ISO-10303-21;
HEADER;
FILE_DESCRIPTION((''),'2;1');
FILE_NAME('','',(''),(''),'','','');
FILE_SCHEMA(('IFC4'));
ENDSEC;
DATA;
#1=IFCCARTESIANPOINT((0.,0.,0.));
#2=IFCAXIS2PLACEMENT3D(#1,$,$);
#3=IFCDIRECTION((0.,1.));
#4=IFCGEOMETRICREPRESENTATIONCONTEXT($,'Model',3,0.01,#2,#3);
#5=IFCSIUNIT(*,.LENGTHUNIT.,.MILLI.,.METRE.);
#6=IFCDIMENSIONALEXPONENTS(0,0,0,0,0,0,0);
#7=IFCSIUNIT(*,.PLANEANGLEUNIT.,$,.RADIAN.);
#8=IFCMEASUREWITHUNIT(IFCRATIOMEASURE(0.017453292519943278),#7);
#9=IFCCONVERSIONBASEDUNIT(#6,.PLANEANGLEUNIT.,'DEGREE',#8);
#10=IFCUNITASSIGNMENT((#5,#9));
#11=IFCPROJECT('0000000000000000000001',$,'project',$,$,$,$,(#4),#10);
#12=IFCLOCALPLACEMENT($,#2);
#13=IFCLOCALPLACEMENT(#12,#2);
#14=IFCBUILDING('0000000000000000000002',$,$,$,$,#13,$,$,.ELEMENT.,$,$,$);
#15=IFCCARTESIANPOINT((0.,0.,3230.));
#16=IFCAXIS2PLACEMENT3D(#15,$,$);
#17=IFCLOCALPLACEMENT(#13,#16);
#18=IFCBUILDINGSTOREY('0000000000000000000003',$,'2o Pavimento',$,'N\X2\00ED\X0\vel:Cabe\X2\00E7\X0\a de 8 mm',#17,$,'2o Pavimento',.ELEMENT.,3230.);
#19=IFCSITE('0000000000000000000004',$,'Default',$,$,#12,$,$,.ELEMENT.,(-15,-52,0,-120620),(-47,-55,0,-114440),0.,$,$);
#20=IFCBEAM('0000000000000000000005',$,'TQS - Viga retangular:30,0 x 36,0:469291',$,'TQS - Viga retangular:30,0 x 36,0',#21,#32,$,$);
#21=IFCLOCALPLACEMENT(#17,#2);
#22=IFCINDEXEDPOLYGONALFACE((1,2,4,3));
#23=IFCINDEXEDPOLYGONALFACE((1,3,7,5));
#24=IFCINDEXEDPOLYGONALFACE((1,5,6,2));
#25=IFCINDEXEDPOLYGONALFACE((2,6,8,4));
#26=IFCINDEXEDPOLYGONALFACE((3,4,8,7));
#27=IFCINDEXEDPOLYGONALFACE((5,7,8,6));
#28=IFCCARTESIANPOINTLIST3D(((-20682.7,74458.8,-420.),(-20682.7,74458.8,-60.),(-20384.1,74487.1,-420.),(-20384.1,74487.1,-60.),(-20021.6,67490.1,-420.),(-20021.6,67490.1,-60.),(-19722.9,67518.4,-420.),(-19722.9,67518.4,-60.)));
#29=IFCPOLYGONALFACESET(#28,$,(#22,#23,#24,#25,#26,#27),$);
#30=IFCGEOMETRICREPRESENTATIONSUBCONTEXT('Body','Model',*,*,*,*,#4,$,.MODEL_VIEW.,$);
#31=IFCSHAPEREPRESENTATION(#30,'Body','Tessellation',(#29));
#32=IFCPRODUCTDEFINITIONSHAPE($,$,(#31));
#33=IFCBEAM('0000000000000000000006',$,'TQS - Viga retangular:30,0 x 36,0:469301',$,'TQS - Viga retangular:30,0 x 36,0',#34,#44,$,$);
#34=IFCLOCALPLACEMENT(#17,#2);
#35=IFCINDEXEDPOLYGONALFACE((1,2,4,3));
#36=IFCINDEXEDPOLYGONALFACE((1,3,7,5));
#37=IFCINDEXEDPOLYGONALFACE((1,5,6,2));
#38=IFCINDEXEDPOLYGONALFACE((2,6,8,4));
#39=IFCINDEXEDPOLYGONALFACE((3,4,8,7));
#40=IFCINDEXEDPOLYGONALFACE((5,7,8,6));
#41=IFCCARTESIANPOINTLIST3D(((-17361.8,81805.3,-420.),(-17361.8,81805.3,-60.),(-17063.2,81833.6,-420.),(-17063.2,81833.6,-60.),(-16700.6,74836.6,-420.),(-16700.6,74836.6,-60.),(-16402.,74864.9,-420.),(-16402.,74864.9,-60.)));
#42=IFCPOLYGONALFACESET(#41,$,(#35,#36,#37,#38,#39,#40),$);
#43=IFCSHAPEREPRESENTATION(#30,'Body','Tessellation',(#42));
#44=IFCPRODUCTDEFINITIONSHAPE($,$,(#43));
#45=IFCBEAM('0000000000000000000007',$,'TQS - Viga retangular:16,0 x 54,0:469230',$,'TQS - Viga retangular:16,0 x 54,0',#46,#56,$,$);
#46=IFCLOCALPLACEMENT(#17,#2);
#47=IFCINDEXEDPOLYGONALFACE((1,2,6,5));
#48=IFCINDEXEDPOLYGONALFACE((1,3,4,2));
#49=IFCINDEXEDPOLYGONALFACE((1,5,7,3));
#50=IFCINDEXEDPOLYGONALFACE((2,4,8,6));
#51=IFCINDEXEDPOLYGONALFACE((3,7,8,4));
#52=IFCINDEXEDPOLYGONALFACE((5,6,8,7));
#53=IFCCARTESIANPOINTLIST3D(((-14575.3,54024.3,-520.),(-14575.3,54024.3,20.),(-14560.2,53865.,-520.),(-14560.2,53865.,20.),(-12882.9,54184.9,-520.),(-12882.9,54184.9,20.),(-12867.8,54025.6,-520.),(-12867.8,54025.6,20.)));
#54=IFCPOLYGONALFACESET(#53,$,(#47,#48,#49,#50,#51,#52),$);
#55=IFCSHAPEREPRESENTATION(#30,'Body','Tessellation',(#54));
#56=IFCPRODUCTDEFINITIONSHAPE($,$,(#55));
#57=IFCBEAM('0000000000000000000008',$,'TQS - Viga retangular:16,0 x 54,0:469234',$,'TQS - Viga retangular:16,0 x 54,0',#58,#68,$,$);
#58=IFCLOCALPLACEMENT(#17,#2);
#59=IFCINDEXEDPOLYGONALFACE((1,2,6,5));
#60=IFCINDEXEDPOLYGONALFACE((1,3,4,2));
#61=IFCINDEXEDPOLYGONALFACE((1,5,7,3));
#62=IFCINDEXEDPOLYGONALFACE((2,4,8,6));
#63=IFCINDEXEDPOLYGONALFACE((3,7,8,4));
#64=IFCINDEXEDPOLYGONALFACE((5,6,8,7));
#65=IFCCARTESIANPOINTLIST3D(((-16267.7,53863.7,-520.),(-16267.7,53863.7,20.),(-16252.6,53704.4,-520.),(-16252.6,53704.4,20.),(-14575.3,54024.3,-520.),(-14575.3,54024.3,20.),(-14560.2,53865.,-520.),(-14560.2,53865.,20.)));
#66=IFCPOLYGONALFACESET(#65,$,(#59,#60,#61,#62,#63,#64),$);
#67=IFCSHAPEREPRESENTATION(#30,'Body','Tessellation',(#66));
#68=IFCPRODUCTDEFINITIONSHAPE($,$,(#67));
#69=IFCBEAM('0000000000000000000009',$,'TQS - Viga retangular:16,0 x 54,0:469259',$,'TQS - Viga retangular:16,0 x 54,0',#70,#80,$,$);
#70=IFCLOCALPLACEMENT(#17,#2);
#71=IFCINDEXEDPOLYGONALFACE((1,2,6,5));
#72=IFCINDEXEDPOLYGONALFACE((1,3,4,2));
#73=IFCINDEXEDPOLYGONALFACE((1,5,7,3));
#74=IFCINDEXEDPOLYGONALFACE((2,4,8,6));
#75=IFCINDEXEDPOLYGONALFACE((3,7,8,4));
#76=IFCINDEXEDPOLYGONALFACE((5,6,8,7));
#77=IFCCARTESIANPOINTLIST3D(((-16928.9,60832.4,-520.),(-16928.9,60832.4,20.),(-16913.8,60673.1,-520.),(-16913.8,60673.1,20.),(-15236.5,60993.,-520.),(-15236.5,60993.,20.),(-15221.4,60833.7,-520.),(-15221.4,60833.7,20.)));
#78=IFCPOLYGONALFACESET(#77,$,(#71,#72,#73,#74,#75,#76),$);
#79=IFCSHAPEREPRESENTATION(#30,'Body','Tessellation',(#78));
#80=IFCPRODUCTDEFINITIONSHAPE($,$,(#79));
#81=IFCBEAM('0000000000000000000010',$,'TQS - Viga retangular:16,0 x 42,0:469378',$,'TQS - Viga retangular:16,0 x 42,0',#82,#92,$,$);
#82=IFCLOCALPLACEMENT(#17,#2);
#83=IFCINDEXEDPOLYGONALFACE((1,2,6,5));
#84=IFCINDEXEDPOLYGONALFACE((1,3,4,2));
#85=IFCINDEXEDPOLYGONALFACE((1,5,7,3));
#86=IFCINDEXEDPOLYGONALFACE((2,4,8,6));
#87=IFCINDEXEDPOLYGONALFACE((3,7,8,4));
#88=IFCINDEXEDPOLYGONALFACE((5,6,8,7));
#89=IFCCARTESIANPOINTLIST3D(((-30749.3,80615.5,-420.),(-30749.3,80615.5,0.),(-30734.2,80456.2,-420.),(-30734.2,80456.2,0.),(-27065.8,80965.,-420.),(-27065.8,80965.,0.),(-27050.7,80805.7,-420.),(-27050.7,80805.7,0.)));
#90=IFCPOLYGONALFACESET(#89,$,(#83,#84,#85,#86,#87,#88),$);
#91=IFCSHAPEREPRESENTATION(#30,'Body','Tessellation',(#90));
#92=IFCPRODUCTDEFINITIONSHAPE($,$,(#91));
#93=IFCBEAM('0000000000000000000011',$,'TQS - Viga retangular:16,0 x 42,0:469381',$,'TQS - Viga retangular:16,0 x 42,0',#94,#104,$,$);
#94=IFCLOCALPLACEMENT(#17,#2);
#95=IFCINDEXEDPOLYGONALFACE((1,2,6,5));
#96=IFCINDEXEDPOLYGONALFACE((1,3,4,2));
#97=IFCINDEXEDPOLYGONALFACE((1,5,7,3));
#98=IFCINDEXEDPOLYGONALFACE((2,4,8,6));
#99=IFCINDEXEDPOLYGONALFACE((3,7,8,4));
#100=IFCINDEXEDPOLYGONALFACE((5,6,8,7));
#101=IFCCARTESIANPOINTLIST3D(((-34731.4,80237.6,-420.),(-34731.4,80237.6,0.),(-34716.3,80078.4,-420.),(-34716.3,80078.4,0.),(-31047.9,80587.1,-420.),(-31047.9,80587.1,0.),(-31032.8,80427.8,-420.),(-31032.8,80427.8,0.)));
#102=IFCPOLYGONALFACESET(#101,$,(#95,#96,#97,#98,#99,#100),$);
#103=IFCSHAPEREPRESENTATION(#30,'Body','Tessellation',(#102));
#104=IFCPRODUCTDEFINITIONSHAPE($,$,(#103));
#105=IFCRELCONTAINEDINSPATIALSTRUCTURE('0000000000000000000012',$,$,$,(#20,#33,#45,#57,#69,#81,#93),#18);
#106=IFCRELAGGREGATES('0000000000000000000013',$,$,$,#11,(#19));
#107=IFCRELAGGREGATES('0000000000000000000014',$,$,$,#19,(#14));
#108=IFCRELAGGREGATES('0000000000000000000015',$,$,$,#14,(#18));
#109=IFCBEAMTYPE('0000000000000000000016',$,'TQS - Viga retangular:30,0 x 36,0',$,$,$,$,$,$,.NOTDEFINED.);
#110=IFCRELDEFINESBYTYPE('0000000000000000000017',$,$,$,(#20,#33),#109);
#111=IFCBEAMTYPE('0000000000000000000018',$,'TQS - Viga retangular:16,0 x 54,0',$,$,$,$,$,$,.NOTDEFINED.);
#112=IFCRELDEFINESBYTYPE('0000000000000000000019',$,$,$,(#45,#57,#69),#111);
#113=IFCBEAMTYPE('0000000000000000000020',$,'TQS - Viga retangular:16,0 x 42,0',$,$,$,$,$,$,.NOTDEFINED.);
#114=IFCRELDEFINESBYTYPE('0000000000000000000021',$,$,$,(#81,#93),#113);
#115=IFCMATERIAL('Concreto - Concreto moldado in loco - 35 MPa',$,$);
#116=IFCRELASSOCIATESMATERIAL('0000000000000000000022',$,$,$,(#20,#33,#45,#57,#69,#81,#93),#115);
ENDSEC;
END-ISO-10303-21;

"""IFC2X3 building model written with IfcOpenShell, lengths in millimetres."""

from ifc_helpers import new_model, entity, si_unit, converted_unit, direction, frame, frame_2d, origin, origin_2d_with_axis, place, context, subcontext, project, spatial, rectangle, extrude, material, type_object, element, save


model = new_model("IFC2X3")

# Units and contexts
model_context = context("Model", 3, precision=0.01, world=origin(), true_north=direction((0.0, 1.0)))
body_context = subcontext(model_context, "Body", "Model", "MODEL_VIEW")
ifc_project = project(units=[si_unit("LENGTHUNIT", "METRE", prefix="MILLI"), converted_unit("PLANEANGLEUNIT", "DEGREE", entity("IfcRatioMeasure", 0.017453292519943278), si_unit("PLANEANGLEUNIT", "RADIAN"), dimensions=[0, 0, 0, 0, 0, 0, 0])], contexts=[model_context])

# Site, building, storey
site_placement = place(None, origin())
site = spatial("IfcSite", under=ifc_project, at=site_placement, Name="Default", CompositionType="ELEMENT", RefLatitude=(-15, -52, 0, -120620), RefLongitude=(-47, -55, 0, -114440), RefElevation=0.0)
building_placement = place(site_placement, origin())
building = spatial("IfcBuilding", under=site, at=building_placement, CompositionType="ELEMENT")
storey_placement = place(building_placement, frame((0.0, 0.0, 3230.0)))
storey = spatial("IfcBuildingStorey", under=building, at=storey_placement, Name="2o Pavimento", ObjectType="Nível:Cabeça de 8 mm", LongName="2o Pavimento", CompositionType="ELEMENT", Elevation=3230.0)

# Beams
ifc_material = material(Name="Concreto - Concreto moldado in loco - 35 MPa")
beam_type_1 = type_object("IfcBeamType", Name="TQS - Viga retangular:30,0 x 36,0", PredefinedType="NOTDEFINED")
beam_1_placement = place(storey_placement, frame((-19872.2, 67504.2, -60.0), z_axis=(0.0, 0.0, 1.0), x_axis=(-0.094456, 0.995529, 0.0)))
element("IfcBeam", 1, at=beam_1_placement, inside=storey, type_object=beam_type_1, material=ifc_material, Name="TQS - Viga retangular:30,0 x 36,0:469291", ObjectType="TQS - Viga retangular:30,0 x 36,0", context=body_context, shape_type="SweptSolid", body=[
    extrude(rectangle(XDim=360.0, YDim=300.0, at=frame_2d((0.0, 0.0), x_axis=(1.0, 0.0))), frame((0.0, 0.0, -180.0), z_axis=(1.0, 0.0, 0.0), x_axis=(0.0, 0.0, -1.0)), (0.0, 0.0, 1.0), 7000.0),
])
beam_2_placement = place(storey_placement, frame((-16551.3, 74850.8, -60.0), z_axis=(0.0, 0.0, 1.0), x_axis=(-0.094456, 0.995529, 0.0)))
element("IfcBeam", 2, at=beam_2_placement, inside=storey, type_object=beam_type_1, material=ifc_material, Name="TQS - Viga retangular:30,0 x 36,0:469301", ObjectType="TQS - Viga retangular:30,0 x 36,0", context=body_context, shape_type="SweptSolid", body=[
    extrude(rectangle(XDim=360.0, YDim=300.0, at=frame_2d((0.0, 0.0), x_axis=(1.0, 0.0))), frame((0.0, 0.0, -180.0), z_axis=(1.0, 0.0, 0.0), x_axis=(0.0, 0.0, -1.0)), (0.0, 0.0, 1.0), 7000.0),
])
beam_type_2 = type_object("IfcBeamType", Name="TQS - Viga retangular:16,0 x 54,0", PredefinedType="NOTDEFINED")
beam_3_placement = place(storey_placement, frame((-12875.3, 54105.2, 20.0), z_axis=(0.0, 0.0, 1.0), x_axis=(-0.995529, -0.094456, 0.0)))
element("IfcBeam", 3, at=beam_3_placement, inside=storey, type_object=beam_type_2, material=ifc_material, Name="TQS - Viga retangular:16,0 x 54,0:469230", ObjectType="TQS - Viga retangular:16,0 x 54,0", context=body_context, shape_type="SweptSolid", body=[
    extrude(rectangle(XDim=540.0, YDim=160.0, at=frame_2d((0.0, 0.0), x_axis=(1.0, 0.0))), frame((0.0, 0.0, -270.0), z_axis=(1.0, 0.0, 0.0), x_axis=(0.0, 0.0, -1.0)), (0.0, 0.0, 1.0), 1700.0),
])
beam_4_placement = place(storey_placement, frame((-14567.7, 53944.7, 20.0), z_axis=(0.0, 0.0, 1.0), x_axis=(-0.995529, -0.094456, 0.0)))
element("IfcBeam", 4, at=beam_4_placement, inside=storey, type_object=beam_type_2, material=ifc_material, Name="TQS - Viga retangular:16,0 x 54,0:469234", ObjectType="TQS - Viga retangular:16,0 x 54,0", context=body_context, shape_type="SweptSolid", body=[
    extrude(rectangle(XDim=540.0, YDim=160.0, at=frame_2d((0.0, 0.0), x_axis=(1.0, 0.0))), frame((0.0, 0.0, -270.0), z_axis=(1.0, 0.0, 0.0), x_axis=(0.0, 0.0, -1.0)), (0.0, 0.0, 1.0), 1700.0),
])
beam_5_placement = place(storey_placement, frame((-15228.9, 60913.4, 20.0), z_axis=(0.0, 0.0, 1.0), x_axis=(-0.995529, -0.094456, 0.0)))
element("IfcBeam", 5, at=beam_5_placement, inside=storey, type_object=beam_type_2, material=ifc_material, Name="TQS - Viga retangular:16,0 x 54,0:469259", ObjectType="TQS - Viga retangular:16,0 x 54,0", context=body_context, shape_type="SweptSolid", body=[
    extrude(rectangle(XDim=540.0, YDim=160.0, at=frame_2d((0.0, 0.0), x_axis=(1.0, 0.0))), frame((0.0, 0.0, -270.0), z_axis=(1.0, 0.0, 0.0), x_axis=(0.0, 0.0, -1.0)), (0.0, 0.0, 1.0), 1700.0),
])
beam_type_3 = type_object("IfcBeamType", Name="TQS - Viga retangular:16,0 x 42,0", PredefinedType="NOTDEFINED")
beam_6_placement = place(storey_placement, frame((-26963.7, 80894.3, 0.0), z_axis=(0.0, 0.0, 1.0), x_axis=(-0.995529, -0.094456, 0.0)))
element("IfcBeam", 6, at=beam_6_placement, inside=storey, type_object=beam_type_3, material=ifc_material, Name="TQS - Viga retangular:16,0 x 42,0:469378", ObjectType="TQS - Viga retangular:16,0 x 42,0", context=body_context, shape_type="SweptSolid", body=[
    extrude(rectangle(XDim=420.0, YDim=160.0, at=origin_2d_with_axis()), frame((95.0, 0.0, -210.0), z_axis=(1.0, 0.0, 0.0), x_axis=(0.0, 0.0, -1.0)), (0.0, 0.0, 1.0), 3700.0),
])
beam_7_placement = place(storey_placement, frame((-30960.7, 80515.0, 0.0), z_axis=(0.0, 0.0, 1.0), x_axis=(-0.995529, -0.094456, 0.0)))
element("IfcBeam", 7, at=beam_7_placement, inside=storey, type_object=beam_type_3, material=ifc_material, Name="TQS - Viga retangular:16,0 x 42,0:469381", ObjectType="TQS - Viga retangular:16,0 x 42,0", context=body_context, shape_type="SweptSolid", body=[
    extrude(rectangle(XDim=420.0, YDim=160.0, at=frame_2d((0.0, 0.0), x_axis=(1.0, 0.0))), frame((80.0, 0.0, -210.0), z_axis=(1.0, 0.0, 0.0), x_axis=(0.0, 0.0, -1.0)), (0.0, 0.0, 1.0), 3700.0),
])

save(model, "model.ifc")
